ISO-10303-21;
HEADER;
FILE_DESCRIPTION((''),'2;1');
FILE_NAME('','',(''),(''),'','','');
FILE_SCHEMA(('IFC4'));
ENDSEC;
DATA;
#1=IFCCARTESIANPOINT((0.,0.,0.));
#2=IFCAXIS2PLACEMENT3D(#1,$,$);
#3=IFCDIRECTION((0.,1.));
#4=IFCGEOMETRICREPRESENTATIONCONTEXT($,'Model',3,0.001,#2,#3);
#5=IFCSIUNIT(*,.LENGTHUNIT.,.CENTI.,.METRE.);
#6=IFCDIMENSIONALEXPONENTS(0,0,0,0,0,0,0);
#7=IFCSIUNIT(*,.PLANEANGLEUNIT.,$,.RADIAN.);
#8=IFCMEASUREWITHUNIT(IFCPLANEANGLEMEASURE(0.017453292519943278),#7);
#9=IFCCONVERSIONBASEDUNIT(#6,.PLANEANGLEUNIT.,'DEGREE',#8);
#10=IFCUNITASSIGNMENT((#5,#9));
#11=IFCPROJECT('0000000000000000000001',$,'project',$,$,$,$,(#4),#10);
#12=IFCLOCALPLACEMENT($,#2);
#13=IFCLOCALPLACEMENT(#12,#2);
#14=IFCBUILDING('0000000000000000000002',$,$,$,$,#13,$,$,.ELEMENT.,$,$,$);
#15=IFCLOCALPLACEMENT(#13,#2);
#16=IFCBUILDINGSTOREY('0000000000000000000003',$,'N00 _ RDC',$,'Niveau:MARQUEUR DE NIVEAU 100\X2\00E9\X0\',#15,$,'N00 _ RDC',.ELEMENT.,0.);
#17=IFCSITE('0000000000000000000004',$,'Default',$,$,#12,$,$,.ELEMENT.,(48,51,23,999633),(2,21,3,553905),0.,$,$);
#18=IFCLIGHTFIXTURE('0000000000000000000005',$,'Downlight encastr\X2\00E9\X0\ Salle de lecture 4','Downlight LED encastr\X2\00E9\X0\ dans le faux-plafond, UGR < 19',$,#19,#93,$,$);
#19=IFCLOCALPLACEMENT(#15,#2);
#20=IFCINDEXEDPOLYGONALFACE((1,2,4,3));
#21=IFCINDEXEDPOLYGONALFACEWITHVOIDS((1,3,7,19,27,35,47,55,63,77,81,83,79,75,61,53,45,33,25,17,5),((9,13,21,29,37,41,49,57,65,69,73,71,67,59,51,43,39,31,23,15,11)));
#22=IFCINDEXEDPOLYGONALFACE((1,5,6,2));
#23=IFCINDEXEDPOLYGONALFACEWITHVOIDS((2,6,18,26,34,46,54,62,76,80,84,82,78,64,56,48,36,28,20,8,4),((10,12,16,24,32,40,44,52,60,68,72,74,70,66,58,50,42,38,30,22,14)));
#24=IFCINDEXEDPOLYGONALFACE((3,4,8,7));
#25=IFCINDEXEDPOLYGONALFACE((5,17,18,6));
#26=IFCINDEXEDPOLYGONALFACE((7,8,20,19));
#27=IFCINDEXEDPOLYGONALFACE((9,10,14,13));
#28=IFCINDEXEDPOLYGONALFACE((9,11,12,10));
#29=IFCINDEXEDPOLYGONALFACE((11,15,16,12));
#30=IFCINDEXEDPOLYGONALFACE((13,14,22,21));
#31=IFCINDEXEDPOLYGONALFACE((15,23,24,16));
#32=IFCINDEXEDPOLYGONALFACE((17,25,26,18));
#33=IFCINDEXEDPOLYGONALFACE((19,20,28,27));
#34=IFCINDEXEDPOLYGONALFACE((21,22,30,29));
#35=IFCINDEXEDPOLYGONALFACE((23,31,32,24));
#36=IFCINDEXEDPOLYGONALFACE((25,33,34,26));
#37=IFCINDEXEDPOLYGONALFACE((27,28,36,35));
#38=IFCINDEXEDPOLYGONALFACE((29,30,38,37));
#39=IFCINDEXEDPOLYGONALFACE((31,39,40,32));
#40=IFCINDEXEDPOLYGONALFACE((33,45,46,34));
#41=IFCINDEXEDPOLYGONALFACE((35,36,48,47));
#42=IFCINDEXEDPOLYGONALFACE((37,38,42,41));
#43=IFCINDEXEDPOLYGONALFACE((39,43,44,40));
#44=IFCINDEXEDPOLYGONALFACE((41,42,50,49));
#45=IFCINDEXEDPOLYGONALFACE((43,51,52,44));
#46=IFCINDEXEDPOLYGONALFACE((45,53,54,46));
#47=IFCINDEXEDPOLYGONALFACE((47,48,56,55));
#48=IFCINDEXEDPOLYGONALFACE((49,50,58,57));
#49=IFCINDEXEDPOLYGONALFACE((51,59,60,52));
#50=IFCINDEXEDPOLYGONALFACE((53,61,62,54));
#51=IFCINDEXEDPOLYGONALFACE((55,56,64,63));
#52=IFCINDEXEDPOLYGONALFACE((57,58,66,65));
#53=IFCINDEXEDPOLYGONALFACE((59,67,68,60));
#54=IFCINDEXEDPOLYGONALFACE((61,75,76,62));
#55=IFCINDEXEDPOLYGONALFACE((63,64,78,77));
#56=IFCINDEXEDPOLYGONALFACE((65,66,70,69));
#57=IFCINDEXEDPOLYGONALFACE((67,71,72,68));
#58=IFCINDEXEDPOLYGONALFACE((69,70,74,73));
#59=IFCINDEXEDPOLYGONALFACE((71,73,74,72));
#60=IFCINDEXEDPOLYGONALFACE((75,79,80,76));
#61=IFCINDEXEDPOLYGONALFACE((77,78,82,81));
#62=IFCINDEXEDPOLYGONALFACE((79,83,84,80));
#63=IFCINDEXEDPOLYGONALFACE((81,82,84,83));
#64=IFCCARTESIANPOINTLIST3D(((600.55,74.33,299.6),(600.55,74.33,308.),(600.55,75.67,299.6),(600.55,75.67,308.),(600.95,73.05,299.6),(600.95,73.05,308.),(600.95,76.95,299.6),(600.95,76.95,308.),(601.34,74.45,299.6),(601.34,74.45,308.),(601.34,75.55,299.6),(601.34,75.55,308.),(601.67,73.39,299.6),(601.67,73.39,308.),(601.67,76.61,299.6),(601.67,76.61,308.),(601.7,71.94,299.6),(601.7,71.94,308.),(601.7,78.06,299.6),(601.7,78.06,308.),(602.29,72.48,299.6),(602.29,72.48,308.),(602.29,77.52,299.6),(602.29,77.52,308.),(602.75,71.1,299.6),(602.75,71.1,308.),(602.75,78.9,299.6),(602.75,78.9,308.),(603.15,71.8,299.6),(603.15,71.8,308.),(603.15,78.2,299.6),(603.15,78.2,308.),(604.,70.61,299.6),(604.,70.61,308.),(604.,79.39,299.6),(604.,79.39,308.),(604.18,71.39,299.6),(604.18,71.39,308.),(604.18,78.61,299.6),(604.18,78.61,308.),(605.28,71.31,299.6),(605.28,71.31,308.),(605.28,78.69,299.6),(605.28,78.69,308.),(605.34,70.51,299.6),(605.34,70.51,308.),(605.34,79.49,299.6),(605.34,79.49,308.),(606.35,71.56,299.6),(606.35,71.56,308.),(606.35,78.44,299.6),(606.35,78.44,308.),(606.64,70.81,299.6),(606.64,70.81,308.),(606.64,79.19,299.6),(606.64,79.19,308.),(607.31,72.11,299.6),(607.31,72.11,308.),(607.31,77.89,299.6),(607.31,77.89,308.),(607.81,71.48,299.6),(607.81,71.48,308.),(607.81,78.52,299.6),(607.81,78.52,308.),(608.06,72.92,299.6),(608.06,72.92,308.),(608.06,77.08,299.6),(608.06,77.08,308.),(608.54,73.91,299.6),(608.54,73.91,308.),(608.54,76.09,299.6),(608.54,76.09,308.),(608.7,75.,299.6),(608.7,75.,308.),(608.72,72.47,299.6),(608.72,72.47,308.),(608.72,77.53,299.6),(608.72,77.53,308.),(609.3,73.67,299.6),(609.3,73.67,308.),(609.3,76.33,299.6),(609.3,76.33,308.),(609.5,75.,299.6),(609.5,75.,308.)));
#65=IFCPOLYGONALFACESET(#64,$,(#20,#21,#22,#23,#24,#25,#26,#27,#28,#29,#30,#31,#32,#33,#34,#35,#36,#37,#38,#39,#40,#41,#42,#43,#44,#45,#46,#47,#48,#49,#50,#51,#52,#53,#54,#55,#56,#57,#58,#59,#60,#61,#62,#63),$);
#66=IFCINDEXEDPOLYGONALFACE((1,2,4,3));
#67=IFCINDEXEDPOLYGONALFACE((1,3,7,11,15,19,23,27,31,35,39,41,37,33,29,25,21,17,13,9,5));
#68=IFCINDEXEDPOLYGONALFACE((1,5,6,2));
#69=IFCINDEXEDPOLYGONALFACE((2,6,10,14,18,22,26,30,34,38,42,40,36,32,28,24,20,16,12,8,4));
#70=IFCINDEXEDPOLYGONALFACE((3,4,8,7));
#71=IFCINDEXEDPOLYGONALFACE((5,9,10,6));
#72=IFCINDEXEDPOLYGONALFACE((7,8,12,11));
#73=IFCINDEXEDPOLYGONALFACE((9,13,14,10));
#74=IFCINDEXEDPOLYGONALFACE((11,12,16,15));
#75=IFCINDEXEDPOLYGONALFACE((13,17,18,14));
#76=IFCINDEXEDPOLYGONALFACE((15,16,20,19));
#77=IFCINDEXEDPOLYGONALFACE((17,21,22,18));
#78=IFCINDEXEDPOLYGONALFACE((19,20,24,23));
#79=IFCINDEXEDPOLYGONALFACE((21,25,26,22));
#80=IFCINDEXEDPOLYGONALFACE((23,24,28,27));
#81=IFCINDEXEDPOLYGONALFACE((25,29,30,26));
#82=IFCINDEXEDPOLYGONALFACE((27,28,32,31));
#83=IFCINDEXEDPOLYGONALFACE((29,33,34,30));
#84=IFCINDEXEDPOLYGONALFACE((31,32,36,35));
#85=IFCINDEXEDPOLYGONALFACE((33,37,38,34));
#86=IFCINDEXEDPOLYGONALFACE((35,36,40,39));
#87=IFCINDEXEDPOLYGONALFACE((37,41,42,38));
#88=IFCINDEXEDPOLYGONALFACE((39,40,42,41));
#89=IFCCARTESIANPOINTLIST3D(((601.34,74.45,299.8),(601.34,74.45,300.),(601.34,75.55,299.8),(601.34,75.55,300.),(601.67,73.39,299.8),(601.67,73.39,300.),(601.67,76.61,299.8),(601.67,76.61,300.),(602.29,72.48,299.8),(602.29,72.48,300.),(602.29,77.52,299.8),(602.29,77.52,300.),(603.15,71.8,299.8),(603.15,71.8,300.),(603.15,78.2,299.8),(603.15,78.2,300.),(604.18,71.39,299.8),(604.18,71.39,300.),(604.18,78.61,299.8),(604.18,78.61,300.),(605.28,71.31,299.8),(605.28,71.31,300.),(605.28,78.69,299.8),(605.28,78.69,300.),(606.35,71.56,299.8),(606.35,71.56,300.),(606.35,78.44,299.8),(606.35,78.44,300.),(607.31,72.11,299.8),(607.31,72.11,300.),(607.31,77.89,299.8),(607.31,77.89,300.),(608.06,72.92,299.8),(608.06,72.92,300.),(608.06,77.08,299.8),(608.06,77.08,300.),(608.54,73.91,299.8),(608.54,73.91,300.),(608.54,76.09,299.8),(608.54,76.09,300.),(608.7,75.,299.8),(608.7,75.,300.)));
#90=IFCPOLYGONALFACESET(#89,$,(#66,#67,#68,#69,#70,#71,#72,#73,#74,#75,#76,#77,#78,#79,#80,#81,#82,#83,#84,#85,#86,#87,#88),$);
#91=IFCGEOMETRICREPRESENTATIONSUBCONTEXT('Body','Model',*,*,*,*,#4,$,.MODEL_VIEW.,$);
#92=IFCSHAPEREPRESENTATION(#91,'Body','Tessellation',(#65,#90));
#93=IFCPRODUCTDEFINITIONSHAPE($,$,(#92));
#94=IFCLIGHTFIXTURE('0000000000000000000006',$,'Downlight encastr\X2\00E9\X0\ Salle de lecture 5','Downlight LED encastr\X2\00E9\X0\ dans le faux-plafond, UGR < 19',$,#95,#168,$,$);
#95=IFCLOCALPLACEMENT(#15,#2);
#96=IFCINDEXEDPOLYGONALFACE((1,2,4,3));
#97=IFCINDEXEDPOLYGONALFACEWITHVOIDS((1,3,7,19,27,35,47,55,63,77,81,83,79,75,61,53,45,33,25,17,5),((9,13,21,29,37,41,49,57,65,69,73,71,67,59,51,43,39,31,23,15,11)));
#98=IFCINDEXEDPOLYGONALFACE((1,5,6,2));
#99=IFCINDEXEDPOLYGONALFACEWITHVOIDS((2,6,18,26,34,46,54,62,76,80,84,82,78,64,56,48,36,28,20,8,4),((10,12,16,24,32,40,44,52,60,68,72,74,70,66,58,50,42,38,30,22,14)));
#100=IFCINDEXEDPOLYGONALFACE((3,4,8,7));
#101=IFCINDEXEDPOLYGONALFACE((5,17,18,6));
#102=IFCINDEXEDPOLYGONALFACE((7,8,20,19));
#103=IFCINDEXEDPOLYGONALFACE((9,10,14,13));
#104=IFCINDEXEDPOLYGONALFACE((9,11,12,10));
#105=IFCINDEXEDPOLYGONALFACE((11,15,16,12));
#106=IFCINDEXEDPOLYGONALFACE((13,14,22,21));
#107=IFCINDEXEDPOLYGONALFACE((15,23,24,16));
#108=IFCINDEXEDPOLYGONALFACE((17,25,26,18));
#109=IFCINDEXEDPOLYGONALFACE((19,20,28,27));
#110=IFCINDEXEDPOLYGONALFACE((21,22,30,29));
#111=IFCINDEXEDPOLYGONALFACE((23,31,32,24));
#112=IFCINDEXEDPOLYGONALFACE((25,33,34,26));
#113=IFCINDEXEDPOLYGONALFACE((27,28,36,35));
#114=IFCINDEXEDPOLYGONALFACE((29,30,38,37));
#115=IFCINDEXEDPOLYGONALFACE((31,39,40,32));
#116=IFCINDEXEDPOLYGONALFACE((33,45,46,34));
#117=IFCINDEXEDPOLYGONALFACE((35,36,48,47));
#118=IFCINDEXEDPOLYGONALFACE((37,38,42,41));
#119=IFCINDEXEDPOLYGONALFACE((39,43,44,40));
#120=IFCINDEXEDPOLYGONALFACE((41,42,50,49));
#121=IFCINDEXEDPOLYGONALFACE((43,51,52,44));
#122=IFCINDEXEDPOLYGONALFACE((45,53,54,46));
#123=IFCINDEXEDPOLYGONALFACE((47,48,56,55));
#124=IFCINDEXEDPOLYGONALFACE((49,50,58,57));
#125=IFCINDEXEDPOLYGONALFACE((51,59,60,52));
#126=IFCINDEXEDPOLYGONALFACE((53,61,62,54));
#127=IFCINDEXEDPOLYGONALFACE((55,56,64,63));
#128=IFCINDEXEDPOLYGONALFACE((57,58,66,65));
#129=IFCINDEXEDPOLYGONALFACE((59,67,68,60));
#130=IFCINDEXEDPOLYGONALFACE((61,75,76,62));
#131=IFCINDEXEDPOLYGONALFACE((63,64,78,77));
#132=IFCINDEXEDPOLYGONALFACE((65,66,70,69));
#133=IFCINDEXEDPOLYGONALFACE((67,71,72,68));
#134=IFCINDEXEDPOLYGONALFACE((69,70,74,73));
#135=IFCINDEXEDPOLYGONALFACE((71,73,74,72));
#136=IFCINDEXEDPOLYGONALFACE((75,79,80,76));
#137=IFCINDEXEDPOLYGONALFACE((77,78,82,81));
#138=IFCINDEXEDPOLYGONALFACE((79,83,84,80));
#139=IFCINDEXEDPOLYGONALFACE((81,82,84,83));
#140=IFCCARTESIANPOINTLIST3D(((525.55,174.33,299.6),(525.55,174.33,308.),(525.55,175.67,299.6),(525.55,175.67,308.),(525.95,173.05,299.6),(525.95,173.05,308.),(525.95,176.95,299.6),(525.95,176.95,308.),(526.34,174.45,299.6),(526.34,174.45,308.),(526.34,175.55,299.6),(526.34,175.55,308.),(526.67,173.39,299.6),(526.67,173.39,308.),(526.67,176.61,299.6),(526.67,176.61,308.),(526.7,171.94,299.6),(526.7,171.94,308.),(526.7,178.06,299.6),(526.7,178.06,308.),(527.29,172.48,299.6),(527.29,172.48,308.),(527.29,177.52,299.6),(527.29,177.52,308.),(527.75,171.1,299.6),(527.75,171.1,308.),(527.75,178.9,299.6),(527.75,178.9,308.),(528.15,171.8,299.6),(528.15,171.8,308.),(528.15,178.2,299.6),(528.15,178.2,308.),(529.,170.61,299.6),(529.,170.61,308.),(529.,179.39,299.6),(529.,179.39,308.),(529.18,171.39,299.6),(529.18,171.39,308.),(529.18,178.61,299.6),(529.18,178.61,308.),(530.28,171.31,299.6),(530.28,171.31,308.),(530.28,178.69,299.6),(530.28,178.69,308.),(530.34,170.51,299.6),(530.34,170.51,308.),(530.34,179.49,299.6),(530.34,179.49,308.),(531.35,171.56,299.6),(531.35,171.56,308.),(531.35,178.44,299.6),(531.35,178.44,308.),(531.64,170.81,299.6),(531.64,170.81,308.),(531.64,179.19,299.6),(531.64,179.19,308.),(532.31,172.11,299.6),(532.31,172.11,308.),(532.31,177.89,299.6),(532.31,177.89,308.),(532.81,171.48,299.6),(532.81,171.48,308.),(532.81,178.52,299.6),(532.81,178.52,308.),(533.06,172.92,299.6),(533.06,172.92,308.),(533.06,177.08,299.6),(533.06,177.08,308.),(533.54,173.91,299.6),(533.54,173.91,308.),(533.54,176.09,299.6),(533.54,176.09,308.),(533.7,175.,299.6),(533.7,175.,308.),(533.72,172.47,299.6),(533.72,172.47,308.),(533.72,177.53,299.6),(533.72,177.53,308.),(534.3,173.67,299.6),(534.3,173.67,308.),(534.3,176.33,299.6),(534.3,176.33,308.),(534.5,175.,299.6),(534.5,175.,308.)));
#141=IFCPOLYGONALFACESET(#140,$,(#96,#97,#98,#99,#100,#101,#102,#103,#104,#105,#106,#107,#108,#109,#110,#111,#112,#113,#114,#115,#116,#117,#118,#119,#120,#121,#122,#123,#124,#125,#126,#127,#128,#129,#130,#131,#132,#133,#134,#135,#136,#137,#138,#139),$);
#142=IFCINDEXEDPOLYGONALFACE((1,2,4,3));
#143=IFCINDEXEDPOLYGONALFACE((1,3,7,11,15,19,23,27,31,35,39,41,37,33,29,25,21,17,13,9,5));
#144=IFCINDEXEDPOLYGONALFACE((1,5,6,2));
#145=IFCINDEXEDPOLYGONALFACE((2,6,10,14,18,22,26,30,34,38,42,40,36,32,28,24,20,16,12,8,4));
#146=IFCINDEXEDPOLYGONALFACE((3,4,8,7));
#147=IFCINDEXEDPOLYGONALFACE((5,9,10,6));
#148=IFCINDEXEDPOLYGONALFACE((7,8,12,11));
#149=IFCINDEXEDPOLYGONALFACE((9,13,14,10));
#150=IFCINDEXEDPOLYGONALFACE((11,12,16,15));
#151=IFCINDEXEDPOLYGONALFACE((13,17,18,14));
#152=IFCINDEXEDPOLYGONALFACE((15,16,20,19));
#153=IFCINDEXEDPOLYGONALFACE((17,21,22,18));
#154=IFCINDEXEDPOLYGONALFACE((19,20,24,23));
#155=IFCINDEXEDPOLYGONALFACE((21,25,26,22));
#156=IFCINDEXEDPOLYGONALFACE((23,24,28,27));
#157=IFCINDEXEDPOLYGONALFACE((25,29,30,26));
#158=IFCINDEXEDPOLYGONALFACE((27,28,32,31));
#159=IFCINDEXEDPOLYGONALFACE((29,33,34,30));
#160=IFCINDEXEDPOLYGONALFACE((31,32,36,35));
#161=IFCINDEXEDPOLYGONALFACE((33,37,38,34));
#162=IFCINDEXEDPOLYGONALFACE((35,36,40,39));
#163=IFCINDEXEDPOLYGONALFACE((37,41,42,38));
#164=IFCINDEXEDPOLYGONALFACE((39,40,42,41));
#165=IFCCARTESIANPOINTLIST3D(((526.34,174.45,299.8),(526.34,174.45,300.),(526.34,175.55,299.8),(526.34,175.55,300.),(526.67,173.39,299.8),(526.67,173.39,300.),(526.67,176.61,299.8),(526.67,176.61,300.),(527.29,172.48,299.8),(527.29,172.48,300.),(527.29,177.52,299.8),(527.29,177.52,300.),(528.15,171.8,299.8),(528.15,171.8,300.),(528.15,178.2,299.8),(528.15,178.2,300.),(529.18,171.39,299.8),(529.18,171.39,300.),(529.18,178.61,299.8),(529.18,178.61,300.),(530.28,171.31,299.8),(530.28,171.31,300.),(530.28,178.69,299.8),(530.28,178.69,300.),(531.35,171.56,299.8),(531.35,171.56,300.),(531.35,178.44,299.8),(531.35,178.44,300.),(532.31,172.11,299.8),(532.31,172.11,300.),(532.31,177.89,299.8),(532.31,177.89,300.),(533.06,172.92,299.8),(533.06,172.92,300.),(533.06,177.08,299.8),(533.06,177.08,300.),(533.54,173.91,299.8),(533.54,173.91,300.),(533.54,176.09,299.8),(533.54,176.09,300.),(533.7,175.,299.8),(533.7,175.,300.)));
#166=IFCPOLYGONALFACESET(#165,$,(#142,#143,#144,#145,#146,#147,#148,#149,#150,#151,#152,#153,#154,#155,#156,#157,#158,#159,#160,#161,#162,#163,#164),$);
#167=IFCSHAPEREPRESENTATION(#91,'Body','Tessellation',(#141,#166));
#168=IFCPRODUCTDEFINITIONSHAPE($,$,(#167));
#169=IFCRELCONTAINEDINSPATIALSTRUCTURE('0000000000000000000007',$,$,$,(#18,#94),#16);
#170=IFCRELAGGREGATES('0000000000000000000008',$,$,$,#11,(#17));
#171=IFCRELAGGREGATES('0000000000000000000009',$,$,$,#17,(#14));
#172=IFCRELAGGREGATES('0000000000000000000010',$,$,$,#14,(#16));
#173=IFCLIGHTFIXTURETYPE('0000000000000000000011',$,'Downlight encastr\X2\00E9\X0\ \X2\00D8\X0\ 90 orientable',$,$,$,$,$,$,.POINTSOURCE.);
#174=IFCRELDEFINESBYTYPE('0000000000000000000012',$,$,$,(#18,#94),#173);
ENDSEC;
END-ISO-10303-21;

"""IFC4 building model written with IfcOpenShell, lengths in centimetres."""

from ifc_helpers import new_model, entity, si_unit, converted_unit, direction, frame, frame_2d, origin, origin_with_axes, place, context, subcontext, project, spatial, circle, hollow_circle, extrude, type_object, element, save


model = new_model("IFC4")

# Units and contexts
model_context = context("Model", 3, precision=0.001, world=origin(), true_north=direction((0.0, 1.0)))
body_context = subcontext(model_context, "Body", "Model", "MODEL_VIEW")
ifc_project = project(units=[si_unit("LENGTHUNIT", "METRE", prefix="CENTI"), converted_unit("PLANEANGLEUNIT", "DEGREE", entity("IfcPlaneAngleMeasure", 0.017453292519943278), si_unit("PLANEANGLEUNIT", "RADIAN"), dimensions=[0, 0, 0, 0, 0, 0, 0])], contexts=[model_context])

# Site, building, storey
site_placement = place(None, origin())
site = spatial("IfcSite", under=ifc_project, at=site_placement, Name="Default", CompositionType="ELEMENT", RefLatitude=(48, 51, 23, 999633), RefLongitude=(2, 21, 3, 553905), RefElevation=0.0)
building_placement = place(site_placement, origin())
building = spatial("IfcBuilding", under=site, at=building_placement, CompositionType="ELEMENT")
storey_placement = place(building_placement, origin())
storey = spatial("IfcBuildingStorey", under=building, at=storey_placement, Name="N00 _ RDC", ObjectType="Niveau:MARQUEUR DE NIVEAU 100é", LongName="N00 _ RDC", CompositionType="ELEMENT", Elevation=0.0)

# Light fixtures
light_fixture_type_1 = type_object("IfcLightFixtureType", Name="Downlight encastré Ø 90 orientable", PredefinedType="POINTSOURCE")
light_fixture_1_placement = place(storey_placement, origin_with_axes())
element("IfcLightFixture", 1, at=light_fixture_1_placement, inside=storey, type_object=light_fixture_type_1, Name="Downlight encastré Salle de lecture 4", Description="Downlight LED encastré dans le faux-plafond, UGR < 19", context=body_context, shape_type="SweptSolid", body=[
    extrude(hollow_circle(Radius=4.5, WallThickness=0.8, at=frame_2d((605.0, 75.0))), frame((0.0, 0.0, 299.6)), (0.0, 0.0, 1.0), 8.4),
    extrude(circle(Radius=3.7, at=frame_2d((605.0, 75.0))), frame((0.0, 0.0, 299.8)), (0.0, 0.0, 1.0), 0.2),
])
light_fixture_2_placement = place(storey_placement, origin_with_axes())
element("IfcLightFixture", 2, at=light_fixture_2_placement, inside=storey, type_object=light_fixture_type_1, Name="Downlight encastré Salle de lecture 5", Description="Downlight LED encastré dans le faux-plafond, UGR < 19", context=body_context, shape_type="SweptSolid", body=[
    extrude(hollow_circle(Radius=4.5, WallThickness=0.8, at=frame_2d((530.0, 175.0))), frame((0.0, 0.0, 299.6)), (0.0, 0.0, 1.0), 8.4),
    extrude(circle(Radius=3.7, at=frame_2d((530.0, 175.0))), frame((0.0, 0.0, 299.8)), (0.0, 0.0, 1.0), 0.2),
])

save(model, "model.ifc")
